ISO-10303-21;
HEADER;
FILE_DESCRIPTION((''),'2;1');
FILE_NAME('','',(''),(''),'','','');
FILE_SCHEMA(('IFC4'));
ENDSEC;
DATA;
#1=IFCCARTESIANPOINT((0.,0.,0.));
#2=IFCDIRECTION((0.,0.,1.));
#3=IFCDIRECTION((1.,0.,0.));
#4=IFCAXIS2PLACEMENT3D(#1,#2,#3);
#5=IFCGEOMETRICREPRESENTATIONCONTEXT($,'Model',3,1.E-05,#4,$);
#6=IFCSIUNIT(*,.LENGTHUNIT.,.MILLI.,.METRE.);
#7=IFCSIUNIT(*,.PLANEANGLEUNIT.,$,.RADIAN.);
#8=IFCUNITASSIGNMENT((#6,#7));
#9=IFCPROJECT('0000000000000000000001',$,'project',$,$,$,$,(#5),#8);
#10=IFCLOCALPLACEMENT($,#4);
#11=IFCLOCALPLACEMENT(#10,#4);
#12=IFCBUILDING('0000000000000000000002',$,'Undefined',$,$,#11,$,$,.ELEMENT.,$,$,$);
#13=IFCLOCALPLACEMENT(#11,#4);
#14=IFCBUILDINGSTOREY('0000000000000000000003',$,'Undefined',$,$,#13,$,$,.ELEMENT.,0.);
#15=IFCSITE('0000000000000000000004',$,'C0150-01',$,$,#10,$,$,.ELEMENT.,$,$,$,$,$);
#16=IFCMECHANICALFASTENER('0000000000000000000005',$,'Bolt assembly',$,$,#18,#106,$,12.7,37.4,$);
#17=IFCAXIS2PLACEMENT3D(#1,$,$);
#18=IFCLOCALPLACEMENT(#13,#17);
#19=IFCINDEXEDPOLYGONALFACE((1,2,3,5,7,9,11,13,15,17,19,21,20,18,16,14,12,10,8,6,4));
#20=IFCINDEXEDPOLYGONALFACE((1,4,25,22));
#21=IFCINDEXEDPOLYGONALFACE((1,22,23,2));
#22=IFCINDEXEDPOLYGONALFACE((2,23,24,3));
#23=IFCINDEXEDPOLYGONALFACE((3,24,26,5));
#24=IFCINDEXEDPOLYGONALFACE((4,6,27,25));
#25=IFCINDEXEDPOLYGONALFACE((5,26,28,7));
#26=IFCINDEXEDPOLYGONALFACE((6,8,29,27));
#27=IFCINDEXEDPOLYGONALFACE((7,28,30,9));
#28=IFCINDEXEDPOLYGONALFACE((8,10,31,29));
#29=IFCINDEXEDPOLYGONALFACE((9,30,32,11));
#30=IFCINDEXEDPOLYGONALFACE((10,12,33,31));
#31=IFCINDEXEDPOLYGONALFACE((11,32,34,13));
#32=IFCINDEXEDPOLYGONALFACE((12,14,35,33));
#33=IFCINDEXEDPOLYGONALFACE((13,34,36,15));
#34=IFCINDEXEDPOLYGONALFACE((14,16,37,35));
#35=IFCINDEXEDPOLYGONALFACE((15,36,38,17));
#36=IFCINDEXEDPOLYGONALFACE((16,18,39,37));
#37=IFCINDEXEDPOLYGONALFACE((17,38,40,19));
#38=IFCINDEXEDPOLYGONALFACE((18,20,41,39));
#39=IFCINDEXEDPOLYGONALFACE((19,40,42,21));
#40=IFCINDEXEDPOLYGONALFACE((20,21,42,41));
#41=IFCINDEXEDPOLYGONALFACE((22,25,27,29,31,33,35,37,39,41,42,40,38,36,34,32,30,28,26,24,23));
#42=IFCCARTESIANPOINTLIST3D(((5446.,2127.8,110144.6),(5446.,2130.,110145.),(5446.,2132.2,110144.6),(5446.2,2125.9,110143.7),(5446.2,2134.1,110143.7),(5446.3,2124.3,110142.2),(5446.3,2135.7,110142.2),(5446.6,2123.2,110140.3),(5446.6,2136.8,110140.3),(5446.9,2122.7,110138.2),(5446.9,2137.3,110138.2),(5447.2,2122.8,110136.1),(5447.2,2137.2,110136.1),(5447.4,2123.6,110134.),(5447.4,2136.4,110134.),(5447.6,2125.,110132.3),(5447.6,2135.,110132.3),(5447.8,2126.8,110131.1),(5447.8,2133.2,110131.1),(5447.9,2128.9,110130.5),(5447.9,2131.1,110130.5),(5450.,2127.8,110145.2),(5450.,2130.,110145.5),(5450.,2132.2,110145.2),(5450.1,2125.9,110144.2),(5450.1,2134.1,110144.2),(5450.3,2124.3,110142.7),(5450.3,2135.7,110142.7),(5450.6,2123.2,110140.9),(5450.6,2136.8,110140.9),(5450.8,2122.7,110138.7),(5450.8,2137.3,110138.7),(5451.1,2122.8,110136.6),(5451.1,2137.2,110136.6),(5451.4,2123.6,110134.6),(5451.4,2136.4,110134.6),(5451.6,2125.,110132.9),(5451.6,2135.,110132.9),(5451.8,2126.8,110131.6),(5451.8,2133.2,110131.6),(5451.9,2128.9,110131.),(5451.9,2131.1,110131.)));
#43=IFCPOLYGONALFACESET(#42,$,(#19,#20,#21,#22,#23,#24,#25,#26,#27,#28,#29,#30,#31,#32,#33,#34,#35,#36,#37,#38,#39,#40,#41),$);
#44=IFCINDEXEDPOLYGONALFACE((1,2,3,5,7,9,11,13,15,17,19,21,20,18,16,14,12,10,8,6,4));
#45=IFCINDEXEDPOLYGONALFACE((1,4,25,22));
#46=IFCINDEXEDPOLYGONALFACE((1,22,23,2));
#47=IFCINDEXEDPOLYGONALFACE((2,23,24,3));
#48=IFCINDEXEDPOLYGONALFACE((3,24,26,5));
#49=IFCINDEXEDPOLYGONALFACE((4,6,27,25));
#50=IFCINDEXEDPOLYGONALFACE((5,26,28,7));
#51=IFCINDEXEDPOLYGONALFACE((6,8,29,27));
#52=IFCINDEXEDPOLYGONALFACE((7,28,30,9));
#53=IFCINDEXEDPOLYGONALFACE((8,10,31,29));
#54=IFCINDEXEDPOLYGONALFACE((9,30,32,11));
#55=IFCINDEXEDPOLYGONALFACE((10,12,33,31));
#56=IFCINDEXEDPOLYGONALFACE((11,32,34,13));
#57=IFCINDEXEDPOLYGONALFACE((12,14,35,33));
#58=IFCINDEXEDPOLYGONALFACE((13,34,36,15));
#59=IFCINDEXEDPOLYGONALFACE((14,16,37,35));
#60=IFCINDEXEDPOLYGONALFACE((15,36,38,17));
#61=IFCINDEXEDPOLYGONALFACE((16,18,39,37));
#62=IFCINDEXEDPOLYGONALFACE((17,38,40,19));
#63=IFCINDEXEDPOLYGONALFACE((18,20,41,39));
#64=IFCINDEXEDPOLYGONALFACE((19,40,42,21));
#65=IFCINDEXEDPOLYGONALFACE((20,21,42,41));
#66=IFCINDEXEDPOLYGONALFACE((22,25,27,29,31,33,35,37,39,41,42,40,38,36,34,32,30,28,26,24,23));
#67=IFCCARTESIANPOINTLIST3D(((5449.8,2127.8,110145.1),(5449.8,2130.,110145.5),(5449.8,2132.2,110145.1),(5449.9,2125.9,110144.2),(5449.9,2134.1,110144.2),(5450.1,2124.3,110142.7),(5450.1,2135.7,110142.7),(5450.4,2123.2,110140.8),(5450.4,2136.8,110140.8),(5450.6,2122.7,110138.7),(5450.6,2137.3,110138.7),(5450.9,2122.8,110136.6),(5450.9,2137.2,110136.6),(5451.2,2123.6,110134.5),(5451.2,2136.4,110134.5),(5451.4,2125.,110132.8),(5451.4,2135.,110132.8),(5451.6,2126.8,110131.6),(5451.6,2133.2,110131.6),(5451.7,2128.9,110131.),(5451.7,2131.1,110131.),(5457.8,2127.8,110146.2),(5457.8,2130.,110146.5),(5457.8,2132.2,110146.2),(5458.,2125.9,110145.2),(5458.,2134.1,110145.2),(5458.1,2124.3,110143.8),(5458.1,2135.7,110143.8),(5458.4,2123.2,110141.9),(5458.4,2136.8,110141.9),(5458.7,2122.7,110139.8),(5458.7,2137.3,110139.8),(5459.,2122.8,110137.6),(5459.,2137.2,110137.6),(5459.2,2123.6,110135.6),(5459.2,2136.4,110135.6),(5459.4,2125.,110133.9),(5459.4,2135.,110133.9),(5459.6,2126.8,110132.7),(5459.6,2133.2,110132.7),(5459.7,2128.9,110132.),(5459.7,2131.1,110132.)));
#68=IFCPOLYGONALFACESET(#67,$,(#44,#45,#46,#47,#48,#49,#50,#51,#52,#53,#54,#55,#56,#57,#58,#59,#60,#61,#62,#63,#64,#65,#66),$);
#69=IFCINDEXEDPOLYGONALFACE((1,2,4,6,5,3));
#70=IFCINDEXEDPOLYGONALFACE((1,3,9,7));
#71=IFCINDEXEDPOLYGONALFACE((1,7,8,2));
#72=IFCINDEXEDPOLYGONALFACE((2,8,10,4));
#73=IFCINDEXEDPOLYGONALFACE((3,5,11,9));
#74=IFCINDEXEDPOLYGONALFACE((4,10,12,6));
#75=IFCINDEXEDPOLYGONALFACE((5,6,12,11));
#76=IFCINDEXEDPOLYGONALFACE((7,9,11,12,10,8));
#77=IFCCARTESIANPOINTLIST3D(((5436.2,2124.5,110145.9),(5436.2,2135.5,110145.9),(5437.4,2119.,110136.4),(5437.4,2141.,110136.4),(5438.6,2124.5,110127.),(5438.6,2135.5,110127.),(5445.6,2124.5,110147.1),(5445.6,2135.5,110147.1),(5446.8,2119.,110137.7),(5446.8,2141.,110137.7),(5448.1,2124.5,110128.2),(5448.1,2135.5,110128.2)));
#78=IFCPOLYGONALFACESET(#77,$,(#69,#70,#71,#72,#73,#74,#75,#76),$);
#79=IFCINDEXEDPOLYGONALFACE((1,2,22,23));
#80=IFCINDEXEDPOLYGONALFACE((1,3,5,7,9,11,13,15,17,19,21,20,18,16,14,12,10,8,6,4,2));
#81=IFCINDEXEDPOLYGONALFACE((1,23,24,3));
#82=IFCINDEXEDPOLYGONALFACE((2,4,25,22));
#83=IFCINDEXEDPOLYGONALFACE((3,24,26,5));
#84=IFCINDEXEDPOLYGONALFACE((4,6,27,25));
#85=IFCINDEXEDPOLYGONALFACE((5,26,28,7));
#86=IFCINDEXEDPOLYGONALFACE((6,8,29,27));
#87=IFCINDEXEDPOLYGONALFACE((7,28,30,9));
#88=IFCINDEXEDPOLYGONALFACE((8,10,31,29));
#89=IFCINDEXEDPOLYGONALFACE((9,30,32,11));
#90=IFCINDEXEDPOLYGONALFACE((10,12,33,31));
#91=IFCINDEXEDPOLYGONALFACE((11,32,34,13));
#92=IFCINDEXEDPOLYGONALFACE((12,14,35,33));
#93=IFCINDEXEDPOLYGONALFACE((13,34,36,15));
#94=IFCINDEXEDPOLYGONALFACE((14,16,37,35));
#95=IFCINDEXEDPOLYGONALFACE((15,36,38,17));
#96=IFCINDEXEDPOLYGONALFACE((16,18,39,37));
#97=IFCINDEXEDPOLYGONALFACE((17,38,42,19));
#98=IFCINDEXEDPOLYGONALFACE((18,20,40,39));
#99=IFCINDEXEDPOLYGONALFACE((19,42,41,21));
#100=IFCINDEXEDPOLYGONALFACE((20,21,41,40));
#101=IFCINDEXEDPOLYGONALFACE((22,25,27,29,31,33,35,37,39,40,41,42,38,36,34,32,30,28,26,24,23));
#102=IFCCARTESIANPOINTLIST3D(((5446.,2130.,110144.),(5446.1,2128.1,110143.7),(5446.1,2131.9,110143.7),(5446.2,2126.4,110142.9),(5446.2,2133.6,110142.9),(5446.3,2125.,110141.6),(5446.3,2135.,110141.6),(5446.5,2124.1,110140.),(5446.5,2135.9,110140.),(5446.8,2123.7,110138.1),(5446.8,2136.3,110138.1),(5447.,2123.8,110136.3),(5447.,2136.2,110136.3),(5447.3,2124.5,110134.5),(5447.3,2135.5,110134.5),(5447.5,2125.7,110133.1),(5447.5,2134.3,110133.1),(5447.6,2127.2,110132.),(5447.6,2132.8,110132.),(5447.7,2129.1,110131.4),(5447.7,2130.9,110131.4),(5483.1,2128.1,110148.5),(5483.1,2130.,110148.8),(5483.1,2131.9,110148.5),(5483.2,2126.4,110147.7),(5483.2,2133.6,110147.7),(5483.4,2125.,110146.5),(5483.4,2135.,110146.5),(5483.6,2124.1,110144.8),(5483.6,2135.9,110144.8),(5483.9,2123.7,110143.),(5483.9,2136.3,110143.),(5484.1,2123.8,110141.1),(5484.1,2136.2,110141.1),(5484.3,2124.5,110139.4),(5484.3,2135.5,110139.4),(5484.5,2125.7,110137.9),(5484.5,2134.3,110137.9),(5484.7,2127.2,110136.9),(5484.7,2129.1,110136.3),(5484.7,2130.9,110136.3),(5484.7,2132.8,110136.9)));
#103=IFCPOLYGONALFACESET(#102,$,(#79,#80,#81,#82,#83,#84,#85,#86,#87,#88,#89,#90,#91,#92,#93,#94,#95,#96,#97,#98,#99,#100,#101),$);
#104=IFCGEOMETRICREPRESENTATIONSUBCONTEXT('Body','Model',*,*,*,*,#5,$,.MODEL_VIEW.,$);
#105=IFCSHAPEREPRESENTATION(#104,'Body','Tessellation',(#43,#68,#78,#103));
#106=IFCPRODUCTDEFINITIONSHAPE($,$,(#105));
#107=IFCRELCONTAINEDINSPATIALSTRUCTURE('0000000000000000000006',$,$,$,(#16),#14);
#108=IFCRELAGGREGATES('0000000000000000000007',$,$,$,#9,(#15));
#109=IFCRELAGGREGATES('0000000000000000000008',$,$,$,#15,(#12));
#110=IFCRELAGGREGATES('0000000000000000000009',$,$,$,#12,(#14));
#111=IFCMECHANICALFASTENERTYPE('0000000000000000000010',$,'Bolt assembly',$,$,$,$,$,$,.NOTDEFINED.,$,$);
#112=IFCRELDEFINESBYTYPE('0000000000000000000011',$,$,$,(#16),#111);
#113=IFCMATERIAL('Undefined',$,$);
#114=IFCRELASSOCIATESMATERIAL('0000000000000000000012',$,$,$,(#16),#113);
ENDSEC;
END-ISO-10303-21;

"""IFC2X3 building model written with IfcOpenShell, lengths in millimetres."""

from ifc_helpers import new_model, si_unit, frame, origin_with_axes, origin_2d_with_axis, place, context, subcontext, project, spatial, polyline, circle, outline, extrude, source, transform, mapped, material, type_object, element, save


model = new_model("IFC2X3")

# Units and contexts
model_context = context("Model", 3, precision=1e-05, world=origin_with_axes())
body_context = subcontext(model_context, "Body", "Model", "MODEL_VIEW")
ifc_project = project(units=[si_unit("LENGTHUNIT", "METRE", prefix="MILLI"), si_unit("PLANEANGLEUNIT", "RADIAN")], contexts=[model_context])

# Site, building, storey
site_placement = place(None, origin_with_axes())
site = spatial("IfcSite", under=ifc_project, at=site_placement, Name="C0150-01", CompositionType="ELEMENT")
building_placement = place(site_placement, origin_with_axes())
building = spatial("IfcBuilding", under=site, at=building_placement, Name="Undefined", CompositionType="ELEMENT")
storey_placement = place(building_placement, origin_with_axes())
storey = spatial("IfcBuildingStorey", under=building, at=storey_placement, Name="Undefined", CompositionType="ELEMENT", Elevation=0.0)

# Mechanical fastener
ifc_material_1 = material(Name="Undefined")
mechanical_fastener_type = type_object("IfcMechanicalFastenerType", Name="Bolt assembly")
shared_shape_1 = source(origin_with_axes(), body_context, "Body", "SweptSolid", [
    extrude(circle(Radius=7.3, at=origin_2d_with_axis()), frame((0.0, -3.9, 0.0), z_axis=(0.0, 1.0, 0.0), x_axis=(1.0, 0.0, 0.0)), (0.0, 0.0, 1.0), 4.0),
    extrude(circle(Radius=7.3, at=origin_2d_with_axis()), frame((0.0, -0.1, 0.0), z_axis=(0.0, 1.0, 0.0), x_axis=(1.0, 0.0, 0.0)), (0.0, 0.0, 1.0), 8.1),
    extrude(outline(polyline([(9.5, -5.5), (9.5, 5.5), (0.0, 11.0), (-9.5, 5.5), (-9.5, -5.5), (0.0, -11.0), (9.5, -5.5)])), frame((0.0, -13.5, 0.0), z_axis=(0.0, 1.0, 0.0), x_axis=(1.0, 0.0, 0.0)), (0.0, 0.0, 1.0), 9.5),
    extrude(circle(Radius=6.3, at=origin_2d_with_axis()), frame((0.0, -4.0, 0.0), z_axis=(0.0, 1.0, 0.0), x_axis=(1.0, 0.0, 0.0)), (0.0, 0.0, 1.0), 37.4),
])
mechanical_fastener_placement = place(storey_placement, frame((5450.8, 2130.0, 110138.2), z_axis=(0.0, 1.0, 0.0), x_axis=(-0.130054, 0.0, 0.991507)))
element("IfcMechanicalFastener", 1, at=mechanical_fastener_placement, inside=storey, type_object=mechanical_fastener_type, material=ifc_material_1, Name="Bolt assembly", NominalDiameter=12.7, NominalLength=37.4, context=body_context, shape_type="MappedRepresentation", body=[
    mapped(shared_shape_1, transform((0.0, 0.0, 0.0))),
])

save(model, "model.ifc")
